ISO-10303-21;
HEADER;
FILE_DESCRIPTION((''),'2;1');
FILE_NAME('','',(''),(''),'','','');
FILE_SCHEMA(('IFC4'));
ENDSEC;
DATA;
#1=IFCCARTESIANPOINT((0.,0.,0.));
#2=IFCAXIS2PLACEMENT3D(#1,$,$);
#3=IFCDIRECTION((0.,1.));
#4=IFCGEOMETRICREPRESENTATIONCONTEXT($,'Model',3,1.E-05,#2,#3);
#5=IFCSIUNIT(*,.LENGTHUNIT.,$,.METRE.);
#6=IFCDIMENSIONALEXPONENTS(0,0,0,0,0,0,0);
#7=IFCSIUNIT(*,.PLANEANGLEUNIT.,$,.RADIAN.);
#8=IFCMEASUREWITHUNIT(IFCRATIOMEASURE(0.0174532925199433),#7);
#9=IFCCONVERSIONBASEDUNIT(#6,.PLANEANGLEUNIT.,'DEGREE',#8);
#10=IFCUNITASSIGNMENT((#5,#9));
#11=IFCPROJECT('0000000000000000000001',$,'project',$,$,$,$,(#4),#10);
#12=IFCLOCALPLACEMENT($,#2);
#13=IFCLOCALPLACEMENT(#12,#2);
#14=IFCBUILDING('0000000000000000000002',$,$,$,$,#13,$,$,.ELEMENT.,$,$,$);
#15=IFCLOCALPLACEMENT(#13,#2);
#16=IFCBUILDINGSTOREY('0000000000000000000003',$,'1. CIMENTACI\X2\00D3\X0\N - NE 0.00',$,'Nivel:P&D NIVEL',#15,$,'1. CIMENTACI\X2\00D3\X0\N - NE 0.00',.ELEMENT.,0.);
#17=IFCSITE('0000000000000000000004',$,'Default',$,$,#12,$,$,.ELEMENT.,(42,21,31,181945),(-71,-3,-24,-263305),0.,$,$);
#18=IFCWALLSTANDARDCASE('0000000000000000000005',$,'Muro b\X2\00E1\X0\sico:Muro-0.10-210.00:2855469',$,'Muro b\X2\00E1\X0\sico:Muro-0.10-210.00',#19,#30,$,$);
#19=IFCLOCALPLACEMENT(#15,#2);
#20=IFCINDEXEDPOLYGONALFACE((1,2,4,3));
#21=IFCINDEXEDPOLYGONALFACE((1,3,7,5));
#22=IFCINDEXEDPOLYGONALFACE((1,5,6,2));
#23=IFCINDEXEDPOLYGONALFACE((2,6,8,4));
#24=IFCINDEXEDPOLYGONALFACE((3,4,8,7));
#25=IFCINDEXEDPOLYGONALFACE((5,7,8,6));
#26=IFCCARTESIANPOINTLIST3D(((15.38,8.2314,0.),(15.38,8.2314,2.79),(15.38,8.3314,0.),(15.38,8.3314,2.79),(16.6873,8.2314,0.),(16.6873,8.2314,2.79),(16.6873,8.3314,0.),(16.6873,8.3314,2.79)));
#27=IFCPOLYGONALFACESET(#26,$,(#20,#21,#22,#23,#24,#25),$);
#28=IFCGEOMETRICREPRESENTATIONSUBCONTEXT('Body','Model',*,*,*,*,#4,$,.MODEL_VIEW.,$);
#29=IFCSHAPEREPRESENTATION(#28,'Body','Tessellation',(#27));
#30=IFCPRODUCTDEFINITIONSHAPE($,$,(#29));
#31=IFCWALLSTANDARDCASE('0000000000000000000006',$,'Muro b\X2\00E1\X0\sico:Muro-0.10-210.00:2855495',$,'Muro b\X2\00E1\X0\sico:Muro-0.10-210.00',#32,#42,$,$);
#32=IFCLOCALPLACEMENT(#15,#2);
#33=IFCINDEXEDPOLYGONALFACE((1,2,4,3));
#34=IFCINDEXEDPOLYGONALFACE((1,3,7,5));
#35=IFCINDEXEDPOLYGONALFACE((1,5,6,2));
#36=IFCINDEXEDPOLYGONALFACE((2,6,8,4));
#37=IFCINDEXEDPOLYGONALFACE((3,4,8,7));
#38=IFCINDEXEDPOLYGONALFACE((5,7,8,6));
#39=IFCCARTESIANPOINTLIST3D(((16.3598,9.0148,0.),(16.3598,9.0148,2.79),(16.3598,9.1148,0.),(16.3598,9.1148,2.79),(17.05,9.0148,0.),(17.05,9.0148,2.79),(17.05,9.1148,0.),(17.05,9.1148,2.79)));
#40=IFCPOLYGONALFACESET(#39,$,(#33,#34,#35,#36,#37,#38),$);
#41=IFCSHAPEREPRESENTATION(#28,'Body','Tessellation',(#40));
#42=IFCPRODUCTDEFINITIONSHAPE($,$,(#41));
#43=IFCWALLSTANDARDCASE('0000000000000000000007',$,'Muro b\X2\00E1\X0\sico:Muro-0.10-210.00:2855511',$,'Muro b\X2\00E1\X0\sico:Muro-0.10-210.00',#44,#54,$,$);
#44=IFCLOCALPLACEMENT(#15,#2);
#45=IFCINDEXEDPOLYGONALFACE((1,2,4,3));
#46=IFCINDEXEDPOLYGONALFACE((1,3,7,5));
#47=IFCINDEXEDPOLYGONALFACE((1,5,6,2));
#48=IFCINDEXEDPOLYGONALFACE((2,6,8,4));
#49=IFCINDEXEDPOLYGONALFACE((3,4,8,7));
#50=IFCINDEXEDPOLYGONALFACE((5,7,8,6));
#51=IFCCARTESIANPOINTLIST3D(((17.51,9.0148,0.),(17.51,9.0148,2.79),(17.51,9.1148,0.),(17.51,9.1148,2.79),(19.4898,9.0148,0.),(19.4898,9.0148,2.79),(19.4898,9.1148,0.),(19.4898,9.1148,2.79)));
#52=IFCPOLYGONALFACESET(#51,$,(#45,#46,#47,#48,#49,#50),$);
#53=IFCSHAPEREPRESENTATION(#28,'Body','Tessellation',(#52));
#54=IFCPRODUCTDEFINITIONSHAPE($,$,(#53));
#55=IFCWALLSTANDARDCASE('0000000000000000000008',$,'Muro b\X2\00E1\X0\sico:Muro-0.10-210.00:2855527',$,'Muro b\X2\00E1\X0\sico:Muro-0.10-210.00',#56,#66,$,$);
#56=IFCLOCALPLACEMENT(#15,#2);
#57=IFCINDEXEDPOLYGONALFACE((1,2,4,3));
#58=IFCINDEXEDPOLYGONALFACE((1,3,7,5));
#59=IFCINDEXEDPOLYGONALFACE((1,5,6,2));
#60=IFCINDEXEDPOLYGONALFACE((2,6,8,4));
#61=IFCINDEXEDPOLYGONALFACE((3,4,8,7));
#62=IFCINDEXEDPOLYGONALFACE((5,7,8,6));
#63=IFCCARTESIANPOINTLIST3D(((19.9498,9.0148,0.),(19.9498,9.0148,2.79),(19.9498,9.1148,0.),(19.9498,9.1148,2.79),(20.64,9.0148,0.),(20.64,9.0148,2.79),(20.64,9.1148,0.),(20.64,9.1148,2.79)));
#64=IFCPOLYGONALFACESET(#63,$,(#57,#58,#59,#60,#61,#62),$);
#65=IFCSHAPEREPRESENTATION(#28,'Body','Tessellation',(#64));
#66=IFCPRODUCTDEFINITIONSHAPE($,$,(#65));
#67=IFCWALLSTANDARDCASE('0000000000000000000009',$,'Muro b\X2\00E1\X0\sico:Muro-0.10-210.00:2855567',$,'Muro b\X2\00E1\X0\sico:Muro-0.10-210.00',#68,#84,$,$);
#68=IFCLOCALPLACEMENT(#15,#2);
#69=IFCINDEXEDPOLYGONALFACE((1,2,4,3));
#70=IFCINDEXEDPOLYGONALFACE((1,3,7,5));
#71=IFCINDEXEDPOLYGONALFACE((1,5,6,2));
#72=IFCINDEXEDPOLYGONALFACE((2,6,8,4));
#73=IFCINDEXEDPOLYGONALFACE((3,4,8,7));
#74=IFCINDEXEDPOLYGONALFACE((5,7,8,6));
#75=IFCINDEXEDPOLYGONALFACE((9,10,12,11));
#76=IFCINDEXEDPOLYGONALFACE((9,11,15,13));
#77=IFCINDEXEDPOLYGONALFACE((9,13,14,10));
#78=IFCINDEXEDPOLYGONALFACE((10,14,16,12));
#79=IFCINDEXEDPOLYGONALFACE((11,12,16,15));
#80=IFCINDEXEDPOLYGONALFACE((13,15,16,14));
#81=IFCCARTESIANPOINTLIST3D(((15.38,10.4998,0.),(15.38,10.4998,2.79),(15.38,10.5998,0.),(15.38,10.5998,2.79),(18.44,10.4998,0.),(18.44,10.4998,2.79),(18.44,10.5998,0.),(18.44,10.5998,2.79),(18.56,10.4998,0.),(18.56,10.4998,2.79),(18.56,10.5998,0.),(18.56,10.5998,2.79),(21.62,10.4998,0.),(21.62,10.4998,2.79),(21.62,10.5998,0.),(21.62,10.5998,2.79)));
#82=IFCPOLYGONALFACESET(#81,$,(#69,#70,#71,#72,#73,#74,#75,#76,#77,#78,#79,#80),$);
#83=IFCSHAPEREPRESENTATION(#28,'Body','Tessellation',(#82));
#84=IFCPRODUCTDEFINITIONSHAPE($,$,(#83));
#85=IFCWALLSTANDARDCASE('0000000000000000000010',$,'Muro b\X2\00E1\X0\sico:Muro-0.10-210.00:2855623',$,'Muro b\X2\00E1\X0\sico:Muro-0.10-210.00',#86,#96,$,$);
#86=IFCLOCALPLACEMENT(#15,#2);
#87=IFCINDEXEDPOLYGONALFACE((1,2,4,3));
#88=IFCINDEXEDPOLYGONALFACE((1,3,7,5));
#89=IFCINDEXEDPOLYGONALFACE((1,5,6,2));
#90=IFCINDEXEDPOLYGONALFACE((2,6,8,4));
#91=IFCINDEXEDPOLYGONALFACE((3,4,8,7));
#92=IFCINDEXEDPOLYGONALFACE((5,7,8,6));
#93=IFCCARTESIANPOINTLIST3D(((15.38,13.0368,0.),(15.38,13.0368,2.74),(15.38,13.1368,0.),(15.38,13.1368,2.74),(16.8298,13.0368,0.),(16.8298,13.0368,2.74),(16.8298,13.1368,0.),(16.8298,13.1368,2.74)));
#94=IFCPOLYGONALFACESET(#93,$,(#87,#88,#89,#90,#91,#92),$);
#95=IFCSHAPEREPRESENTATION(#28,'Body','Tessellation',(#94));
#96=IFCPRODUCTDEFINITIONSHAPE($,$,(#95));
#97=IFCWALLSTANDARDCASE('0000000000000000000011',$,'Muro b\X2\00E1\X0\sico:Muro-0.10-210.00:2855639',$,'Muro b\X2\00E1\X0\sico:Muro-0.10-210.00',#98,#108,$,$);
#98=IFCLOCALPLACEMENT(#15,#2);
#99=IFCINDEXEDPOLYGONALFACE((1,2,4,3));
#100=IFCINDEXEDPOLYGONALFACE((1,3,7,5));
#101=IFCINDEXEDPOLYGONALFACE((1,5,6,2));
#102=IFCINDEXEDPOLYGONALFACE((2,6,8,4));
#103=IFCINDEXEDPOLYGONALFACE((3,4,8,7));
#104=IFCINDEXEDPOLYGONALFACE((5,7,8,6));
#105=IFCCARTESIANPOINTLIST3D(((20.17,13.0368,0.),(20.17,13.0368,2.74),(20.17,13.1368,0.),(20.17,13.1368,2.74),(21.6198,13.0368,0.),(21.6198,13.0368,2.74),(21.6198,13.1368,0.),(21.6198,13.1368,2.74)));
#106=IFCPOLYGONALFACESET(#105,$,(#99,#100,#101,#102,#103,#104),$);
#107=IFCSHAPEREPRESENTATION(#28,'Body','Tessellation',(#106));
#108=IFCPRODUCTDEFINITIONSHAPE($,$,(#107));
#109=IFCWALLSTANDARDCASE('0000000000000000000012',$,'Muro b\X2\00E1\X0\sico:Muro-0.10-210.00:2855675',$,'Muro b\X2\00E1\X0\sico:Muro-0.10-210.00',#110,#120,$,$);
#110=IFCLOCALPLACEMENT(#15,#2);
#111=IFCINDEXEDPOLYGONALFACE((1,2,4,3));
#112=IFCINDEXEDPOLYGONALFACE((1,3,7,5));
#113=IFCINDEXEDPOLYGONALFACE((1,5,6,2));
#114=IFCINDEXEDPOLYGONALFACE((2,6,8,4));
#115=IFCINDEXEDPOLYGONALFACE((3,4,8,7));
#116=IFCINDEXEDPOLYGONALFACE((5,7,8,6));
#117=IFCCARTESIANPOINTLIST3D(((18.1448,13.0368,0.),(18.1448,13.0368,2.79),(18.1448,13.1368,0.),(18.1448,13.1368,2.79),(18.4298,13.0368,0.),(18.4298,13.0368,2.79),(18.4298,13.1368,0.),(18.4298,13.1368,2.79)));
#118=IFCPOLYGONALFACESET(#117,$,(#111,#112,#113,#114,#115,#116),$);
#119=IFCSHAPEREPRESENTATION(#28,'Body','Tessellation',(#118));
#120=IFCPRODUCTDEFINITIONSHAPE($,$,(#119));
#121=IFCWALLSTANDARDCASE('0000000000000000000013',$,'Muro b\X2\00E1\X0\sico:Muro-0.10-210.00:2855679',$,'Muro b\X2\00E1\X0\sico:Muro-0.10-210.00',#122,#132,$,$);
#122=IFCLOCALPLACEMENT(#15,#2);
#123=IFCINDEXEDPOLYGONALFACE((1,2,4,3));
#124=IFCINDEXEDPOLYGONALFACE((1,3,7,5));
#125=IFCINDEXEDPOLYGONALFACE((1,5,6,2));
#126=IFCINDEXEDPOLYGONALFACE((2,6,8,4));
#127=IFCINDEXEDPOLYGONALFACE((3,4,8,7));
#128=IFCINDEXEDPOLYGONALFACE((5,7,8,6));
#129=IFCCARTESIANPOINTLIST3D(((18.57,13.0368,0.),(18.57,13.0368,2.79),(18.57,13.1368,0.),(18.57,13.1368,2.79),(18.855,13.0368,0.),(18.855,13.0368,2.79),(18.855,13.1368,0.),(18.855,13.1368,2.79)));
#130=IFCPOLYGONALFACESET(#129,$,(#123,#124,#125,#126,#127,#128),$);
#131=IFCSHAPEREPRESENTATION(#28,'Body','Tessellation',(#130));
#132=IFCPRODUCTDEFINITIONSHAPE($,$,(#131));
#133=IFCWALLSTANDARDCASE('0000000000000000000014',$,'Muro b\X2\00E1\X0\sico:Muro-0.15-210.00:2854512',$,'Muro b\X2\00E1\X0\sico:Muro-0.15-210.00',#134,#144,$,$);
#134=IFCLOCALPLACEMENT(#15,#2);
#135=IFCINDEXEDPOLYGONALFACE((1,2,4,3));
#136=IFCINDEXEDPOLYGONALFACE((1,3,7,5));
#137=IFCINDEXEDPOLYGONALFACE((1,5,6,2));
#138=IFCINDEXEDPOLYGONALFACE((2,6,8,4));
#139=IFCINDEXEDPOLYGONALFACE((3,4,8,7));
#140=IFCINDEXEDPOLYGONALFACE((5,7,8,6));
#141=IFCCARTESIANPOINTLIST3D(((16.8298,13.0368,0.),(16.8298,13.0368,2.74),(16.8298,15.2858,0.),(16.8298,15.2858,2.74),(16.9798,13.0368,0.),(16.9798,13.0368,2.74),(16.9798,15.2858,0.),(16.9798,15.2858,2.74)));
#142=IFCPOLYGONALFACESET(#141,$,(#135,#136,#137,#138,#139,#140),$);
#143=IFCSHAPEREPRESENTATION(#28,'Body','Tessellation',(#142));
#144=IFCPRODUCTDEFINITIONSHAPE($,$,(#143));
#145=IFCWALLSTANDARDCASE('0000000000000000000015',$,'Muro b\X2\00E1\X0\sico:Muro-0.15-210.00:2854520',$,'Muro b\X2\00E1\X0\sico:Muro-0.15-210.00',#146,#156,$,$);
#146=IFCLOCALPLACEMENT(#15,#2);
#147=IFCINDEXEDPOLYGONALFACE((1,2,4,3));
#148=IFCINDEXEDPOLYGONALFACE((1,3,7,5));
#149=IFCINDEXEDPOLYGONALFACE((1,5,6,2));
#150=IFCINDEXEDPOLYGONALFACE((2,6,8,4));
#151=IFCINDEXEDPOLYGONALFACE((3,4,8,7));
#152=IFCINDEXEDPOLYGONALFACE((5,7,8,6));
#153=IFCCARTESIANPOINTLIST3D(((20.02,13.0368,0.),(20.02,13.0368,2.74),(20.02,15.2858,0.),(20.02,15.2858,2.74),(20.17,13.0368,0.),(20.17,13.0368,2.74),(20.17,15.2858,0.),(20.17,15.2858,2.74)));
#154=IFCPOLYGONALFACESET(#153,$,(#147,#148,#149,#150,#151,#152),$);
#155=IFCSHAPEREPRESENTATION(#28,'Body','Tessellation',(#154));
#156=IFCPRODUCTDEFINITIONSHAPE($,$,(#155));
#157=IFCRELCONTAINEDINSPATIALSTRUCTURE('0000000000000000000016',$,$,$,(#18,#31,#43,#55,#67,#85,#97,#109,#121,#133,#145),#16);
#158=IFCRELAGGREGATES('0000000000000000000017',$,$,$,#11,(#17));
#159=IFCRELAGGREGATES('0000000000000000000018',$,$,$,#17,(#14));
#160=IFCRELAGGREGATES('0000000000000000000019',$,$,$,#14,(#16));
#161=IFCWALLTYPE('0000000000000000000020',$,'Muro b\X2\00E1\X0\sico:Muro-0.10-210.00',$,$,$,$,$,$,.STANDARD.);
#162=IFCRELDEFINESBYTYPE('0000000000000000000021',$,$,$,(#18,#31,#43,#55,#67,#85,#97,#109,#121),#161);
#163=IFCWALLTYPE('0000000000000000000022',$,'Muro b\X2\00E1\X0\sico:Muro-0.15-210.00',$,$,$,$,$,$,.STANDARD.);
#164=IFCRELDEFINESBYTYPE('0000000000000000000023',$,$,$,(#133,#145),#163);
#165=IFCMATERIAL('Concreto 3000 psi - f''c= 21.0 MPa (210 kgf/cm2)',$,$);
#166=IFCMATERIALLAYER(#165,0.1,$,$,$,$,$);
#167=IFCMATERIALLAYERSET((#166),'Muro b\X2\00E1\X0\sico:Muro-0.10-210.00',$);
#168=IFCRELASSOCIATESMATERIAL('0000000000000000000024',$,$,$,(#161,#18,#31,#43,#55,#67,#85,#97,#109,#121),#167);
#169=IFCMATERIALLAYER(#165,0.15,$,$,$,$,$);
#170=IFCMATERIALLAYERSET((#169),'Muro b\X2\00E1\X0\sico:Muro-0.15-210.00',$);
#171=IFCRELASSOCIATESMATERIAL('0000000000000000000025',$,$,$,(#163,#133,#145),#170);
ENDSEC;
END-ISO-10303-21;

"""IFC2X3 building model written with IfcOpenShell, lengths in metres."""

from ifc_helpers import new_model, entity, si_unit, converted_unit, direction, frame, frame_2d, origin, place, context, subcontext, project, spatial, rectangle, extrude, material, layer, layer_set, layer_usage, type_object, element, save


model = new_model("IFC2X3")

# Units and contexts
model_context = context("Model", 3, precision=1e-05, world=origin(), true_north=direction((0.0, 1.0)))
body_context = subcontext(model_context, "Body", "Model", "MODEL_VIEW")
ifc_project = project(units=[si_unit("LENGTHUNIT", "METRE"), converted_unit("PLANEANGLEUNIT", "DEGREE", entity("IfcRatioMeasure", 0.0174532925199433), si_unit("PLANEANGLEUNIT", "RADIAN"), dimensions=[0, 0, 0, 0, 0, 0, 0])], contexts=[model_context])

# Site, building, storey
site_placement = place(None, origin())
site = spatial("IfcSite", under=ifc_project, at=site_placement, Name="Default", CompositionType="ELEMENT", RefLatitude=(42, 21, 31, 181945), RefLongitude=(-71, -3, -24, -263305), RefElevation=0.0)
building_placement = place(site_placement, origin())
building = spatial("IfcBuilding", under=site, at=building_placement, CompositionType="ELEMENT")
storey_placement = place(building_placement, origin())
storey = spatial("IfcBuildingStorey", under=building, at=storey_placement, Name="1. CIMENTACIÓN - NE 0.00", ObjectType="Nivel:P&D NIVEL", LongName="1. CIMENTACIÓN - NE 0.00", CompositionType="ELEMENT", Elevation=0.0)

# Shared definitions
ifc_material = material(Name="Concreto 3000 psi - f'c= 21.0 MPa (210 kgf/cm2)")

# Walls
ifc_layer_1 = layer(ifc_material, 0.1)
ifc_layer_set_1 = layer_set([ifc_layer_1], Name="Muro básico:Muro-0.10-210.00")
ifc_layer_usage_1 = layer_usage(ifc_layer_set_1, "AXIS2", "POSITIVE", -0.05)
wall_type_1 = type_object("IfcWallType", Name="Muro básico:Muro-0.10-210.00", PredefinedType="STANDARD", material=ifc_layer_set_1)
wall_1_placement = place(storey_placement, frame((15.38, 8.2814, 0.0)))
element("IfcWallStandardCase", 1, at=wall_1_placement, inside=storey, type_object=wall_type_1, material=ifc_layer_usage_1, Name="Muro básico:Muro-0.10-210.00:2855469", ObjectType="Muro básico:Muro-0.10-210.00", context=body_context, shape_type="SweptSolid", body=[
    extrude(rectangle(XDim=1.3073, YDim=0.1, at=frame_2d((0.6536, 0.0), x_axis=(-1.0, 0.0))), origin(), (0.0, 0.0, 1.0), 2.79),
])
wall_2_placement = place(storey_placement, frame((16.3598, 9.0648, 0.0)))
element("IfcWallStandardCase", 2, at=wall_2_placement, inside=storey, type_object=wall_type_1, material=ifc_layer_usage_1, Name="Muro básico:Muro-0.10-210.00:2855495", ObjectType="Muro básico:Muro-0.10-210.00", context=body_context, shape_type="SweptSolid", body=[
    extrude(rectangle(XDim=0.6902, YDim=0.1, at=frame_2d((0.3451, 0.0), x_axis=(-1.0, 0.0))), origin(), (0.0, 0.0, 1.0), 2.79),
])
wall_3_placement = place(storey_placement, frame((17.51, 9.0648, 0.0)))
element("IfcWallStandardCase", 3, at=wall_3_placement, inside=storey, type_object=wall_type_1, material=ifc_layer_usage_1, Name="Muro básico:Muro-0.10-210.00:2855511", ObjectType="Muro básico:Muro-0.10-210.00", context=body_context, shape_type="SweptSolid", body=[
    extrude(rectangle(XDim=1.9798, YDim=0.1, at=frame_2d((0.9899, 0.0), x_axis=(-1.0, 0.0))), origin(), (0.0, 0.0, 1.0), 2.79),
])
wall_4_placement = place(storey_placement, frame((19.9498, 9.0648, 0.0)))
element("IfcWallStandardCase", 4, at=wall_4_placement, inside=storey, type_object=wall_type_1, material=ifc_layer_usage_1, Name="Muro básico:Muro-0.10-210.00:2855527", ObjectType="Muro básico:Muro-0.10-210.00", context=body_context, shape_type="SweptSolid", body=[
    extrude(rectangle(XDim=0.6902, YDim=0.1, at=frame_2d((0.3451, 0.0), x_axis=(-1.0, 0.0))), origin(), (0.0, 0.0, 1.0), 2.79),
])

# Wall, opening
wall_5_placement = place(storey_placement, frame((15.38, 10.5498, 0.0)))
wall_5 = element("IfcWallStandardCase", 5, at=wall_5_placement, inside=storey, type_object=wall_type_1, material=ifc_layer_usage_1, Name="Muro básico:Muro-0.10-210.00:2855567", ObjectType="Muro básico:Muro-0.10-210.00", context=body_context, shape_type="SweptSolid", body=[
    extrude(rectangle(XDim=6.24, YDim=0.1, at=frame_2d((3.12, 0.0), x_axis=(-1.0, 0.0))), origin(), (0.0, 0.0, 1.0), 2.79),
])
opening_placement = place(storey_placement, frame((15.38, 10.5498, 0.0)))
element("IfcOpeningElement", 6, at=opening_placement, cuts=wall_5, ObjectType="Opening", context=body_context, shape_type="SweptSolid", body=[
    extrude(rectangle(XDim=2.79, YDim=0.1, at=frame_2d((0.0, 0.0), x_axis=(1.0, 0.0))), frame((3.06, 0.0, 1.395), z_axis=(1.0, 0.0, 0.0), x_axis=(0.0, 0.0, -1.0)), (0.0, 0.0, 1.0), 0.12),
])

# Walls
wall_6_placement = place(storey_placement, frame((15.38, 13.0868, 0.0)))
element("IfcWallStandardCase", 7, at=wall_6_placement, inside=storey, type_object=wall_type_1, material=ifc_layer_usage_1, Name="Muro básico:Muro-0.10-210.00:2855623", ObjectType="Muro básico:Muro-0.10-210.00", context=body_context, shape_type="SweptSolid", body=[
    extrude(rectangle(XDim=1.4498, YDim=0.1, at=frame_2d((0.7249, 0.0), x_axis=(-1.0, 0.0))), origin(), (0.0, 0.0, 1.0), 2.74),
])
wall_7_placement = place(storey_placement, frame((20.17, 13.0868, 0.0)))
element("IfcWallStandardCase", 8, at=wall_7_placement, inside=storey, type_object=wall_type_1, material=ifc_layer_usage_1, Name="Muro básico:Muro-0.10-210.00:2855639", ObjectType="Muro básico:Muro-0.10-210.00", context=body_context, shape_type="SweptSolid", body=[
    extrude(rectangle(XDim=1.4498, YDim=0.1, at=frame_2d((0.7249, 0.0), x_axis=(-1.0, 0.0))), origin(), (0.0, 0.0, 1.0), 2.74),
])
wall_8_placement = place(storey_placement, frame((18.1448, 13.0868, 0.0)))
element("IfcWallStandardCase", 9, at=wall_8_placement, inside=storey, type_object=wall_type_1, material=ifc_layer_usage_1, Name="Muro básico:Muro-0.10-210.00:2855675", ObjectType="Muro básico:Muro-0.10-210.00", context=body_context, shape_type="SweptSolid", body=[
    extrude(rectangle(XDim=0.285, YDim=0.1, at=frame_2d((0.1425, 0.0), x_axis=(-1.0, 0.0))), origin(), (0.0, 0.0, 1.0), 2.79),
])
wall_9_placement = place(storey_placement, frame((18.57, 13.0868, 0.0)))
element("IfcWallStandardCase", 10, at=wall_9_placement, inside=storey, type_object=wall_type_1, material=ifc_layer_usage_1, Name="Muro básico:Muro-0.10-210.00:2855679", ObjectType="Muro básico:Muro-0.10-210.00", context=body_context, shape_type="SweptSolid", body=[
    extrude(rectangle(XDim=0.285, YDim=0.1, at=frame_2d((0.1425, 0.0), x_axis=(-1.0, 0.0))), origin(), (0.0, 0.0, 1.0), 2.79),
])
ifc_layer_2 = layer(ifc_material, 0.15)
ifc_layer_set_2 = layer_set([ifc_layer_2], Name="Muro básico:Muro-0.15-210.00")
ifc_layer_usage_2 = layer_usage(ifc_layer_set_2, "AXIS2", "POSITIVE", -0.075)
wall_type_2 = type_object("IfcWallType", Name="Muro básico:Muro-0.15-210.00", PredefinedType="STANDARD", material=ifc_layer_set_2)
for number, where, z_axis, x_axis, name in (
    (11, (16.9048, 13.0368, 0.0), (0.0, 0.0, 1.0), (0.0, 1.0, 0.0), "Muro básico:Muro-0.15-210.00:2854512"),
    (12, (20.095, 13.0368, 0.0), (0.0, 0.0, 1.0), (0.0, 1.0, 0.0), "Muro básico:Muro-0.15-210.00:2854520"),
):
    element("IfcWallStandardCase", number, at=place(storey_placement, frame(where, z_axis=z_axis, x_axis=x_axis)), inside=storey, type_object=wall_type_2, material=ifc_layer_usage_2, Name=name, ObjectType="Muro básico:Muro-0.15-210.00", context=body_context, shape_type="SweptSolid", body=[
        extrude(rectangle(XDim=2.249, YDim=0.15, at=frame_2d((1.1245, 0.0), x_axis=(-1.0, 0.0))), origin(), (0.0, 0.0, 1.0), 2.74),
    ])

save(model, "model.ifc")
